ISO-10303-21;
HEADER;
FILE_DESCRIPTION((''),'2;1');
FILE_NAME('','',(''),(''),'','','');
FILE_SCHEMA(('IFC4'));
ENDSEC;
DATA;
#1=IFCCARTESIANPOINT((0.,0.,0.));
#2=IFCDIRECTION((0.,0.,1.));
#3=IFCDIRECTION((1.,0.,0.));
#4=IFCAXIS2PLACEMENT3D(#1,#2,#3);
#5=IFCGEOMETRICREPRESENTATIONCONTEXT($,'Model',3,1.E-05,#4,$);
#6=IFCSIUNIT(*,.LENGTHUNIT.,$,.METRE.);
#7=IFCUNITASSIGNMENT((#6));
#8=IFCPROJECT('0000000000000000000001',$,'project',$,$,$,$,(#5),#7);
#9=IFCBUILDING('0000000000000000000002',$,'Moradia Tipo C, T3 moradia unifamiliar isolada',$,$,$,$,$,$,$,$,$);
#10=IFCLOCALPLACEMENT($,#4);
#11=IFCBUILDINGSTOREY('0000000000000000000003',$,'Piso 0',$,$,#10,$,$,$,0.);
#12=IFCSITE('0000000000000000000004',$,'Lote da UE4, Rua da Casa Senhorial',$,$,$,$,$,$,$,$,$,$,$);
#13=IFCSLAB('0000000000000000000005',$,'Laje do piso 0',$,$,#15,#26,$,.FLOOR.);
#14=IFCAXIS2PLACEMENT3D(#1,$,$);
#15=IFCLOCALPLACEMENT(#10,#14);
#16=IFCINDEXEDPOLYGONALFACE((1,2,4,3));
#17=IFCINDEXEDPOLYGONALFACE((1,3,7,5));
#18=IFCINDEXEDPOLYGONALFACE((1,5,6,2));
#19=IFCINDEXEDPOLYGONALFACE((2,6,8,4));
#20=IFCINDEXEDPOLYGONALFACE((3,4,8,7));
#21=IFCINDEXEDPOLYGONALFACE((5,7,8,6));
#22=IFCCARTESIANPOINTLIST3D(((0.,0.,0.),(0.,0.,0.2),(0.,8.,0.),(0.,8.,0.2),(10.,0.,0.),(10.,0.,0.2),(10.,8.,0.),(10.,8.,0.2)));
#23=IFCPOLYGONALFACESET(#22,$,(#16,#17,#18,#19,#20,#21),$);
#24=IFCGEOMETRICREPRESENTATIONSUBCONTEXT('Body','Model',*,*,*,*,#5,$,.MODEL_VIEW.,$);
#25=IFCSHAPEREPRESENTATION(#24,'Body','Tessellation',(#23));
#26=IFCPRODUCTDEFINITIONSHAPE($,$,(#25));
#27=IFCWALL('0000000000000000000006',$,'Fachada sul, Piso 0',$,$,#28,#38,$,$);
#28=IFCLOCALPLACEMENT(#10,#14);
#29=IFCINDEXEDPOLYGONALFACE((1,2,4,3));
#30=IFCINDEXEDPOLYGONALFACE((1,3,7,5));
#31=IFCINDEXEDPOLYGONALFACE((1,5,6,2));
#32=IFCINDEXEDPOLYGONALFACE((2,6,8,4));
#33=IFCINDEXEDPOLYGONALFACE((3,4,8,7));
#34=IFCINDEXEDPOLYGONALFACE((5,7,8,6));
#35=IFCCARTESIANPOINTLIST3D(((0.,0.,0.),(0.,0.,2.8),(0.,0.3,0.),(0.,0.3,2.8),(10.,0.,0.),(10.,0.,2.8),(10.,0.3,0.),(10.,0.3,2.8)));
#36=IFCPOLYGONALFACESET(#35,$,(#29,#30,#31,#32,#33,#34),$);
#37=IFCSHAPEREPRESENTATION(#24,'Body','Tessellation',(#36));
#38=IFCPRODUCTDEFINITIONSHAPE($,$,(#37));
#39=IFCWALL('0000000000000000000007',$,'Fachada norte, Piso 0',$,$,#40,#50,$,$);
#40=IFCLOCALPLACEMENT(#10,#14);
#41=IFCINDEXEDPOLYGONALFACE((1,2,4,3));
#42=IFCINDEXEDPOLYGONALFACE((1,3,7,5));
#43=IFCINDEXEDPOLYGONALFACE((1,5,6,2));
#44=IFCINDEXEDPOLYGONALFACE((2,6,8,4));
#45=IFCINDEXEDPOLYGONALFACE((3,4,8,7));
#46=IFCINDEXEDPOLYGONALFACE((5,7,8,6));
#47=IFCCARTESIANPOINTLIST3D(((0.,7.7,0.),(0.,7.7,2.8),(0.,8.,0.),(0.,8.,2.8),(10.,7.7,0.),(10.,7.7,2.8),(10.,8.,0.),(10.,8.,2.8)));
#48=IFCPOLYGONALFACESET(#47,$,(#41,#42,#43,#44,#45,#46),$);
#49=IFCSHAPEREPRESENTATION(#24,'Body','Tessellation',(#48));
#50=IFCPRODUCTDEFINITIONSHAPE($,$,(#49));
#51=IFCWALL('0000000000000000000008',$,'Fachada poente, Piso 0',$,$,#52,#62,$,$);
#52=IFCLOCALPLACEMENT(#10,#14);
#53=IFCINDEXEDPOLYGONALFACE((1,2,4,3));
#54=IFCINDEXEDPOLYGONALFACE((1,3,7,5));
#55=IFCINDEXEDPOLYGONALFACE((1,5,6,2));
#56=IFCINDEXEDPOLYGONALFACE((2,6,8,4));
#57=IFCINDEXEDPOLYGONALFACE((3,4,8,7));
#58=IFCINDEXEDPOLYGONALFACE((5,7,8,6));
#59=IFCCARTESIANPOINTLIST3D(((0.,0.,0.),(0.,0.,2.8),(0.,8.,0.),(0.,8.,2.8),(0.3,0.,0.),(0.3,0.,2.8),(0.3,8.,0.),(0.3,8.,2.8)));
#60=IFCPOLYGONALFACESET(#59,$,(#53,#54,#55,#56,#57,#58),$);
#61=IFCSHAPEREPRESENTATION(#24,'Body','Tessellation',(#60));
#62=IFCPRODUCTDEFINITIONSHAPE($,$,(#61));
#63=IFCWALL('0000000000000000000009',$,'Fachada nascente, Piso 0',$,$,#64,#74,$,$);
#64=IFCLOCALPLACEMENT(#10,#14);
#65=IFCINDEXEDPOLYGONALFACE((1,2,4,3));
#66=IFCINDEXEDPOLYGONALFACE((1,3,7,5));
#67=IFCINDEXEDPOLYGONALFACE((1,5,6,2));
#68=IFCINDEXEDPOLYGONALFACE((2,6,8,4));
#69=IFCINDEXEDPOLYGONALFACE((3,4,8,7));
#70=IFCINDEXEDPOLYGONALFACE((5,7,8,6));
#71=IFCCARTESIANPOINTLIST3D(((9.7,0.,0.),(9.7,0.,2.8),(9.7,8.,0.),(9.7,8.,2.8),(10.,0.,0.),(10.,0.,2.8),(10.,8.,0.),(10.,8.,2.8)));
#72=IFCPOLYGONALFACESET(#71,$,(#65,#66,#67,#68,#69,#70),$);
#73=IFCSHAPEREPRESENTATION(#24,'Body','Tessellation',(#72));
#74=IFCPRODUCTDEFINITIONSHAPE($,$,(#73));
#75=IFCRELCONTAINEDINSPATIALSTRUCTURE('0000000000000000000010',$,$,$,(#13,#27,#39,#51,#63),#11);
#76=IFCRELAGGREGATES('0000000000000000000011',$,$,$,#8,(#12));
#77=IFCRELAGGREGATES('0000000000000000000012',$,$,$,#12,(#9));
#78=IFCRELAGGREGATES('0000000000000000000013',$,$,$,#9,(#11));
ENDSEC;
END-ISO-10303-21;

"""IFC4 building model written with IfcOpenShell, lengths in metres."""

from ifc_helpers import new_model, si_unit, frame, origin_with_axes, place, context, subcontext, project, spatial, indexed_curve, outline, extrude, element, save


model = new_model("IFC4")

# Units and contexts
model_context = context("Model", 3, precision=1e-05, world=origin_with_axes())
body_context = subcontext(model_context, "Body", "Model", "MODEL_VIEW")
ifc_project = project(units=[si_unit("LENGTHUNIT", "METRE")], contexts=[model_context])

# Site, building, storey
site = spatial("IfcSite", under=ifc_project, Name="Lote da UE4, Rua da Casa Senhorial")
building = spatial("IfcBuilding", under=site, Name="Moradia Tipo C, T3 moradia unifamiliar isolada")
storey_placement = place(None, origin_with_axes())
storey = spatial("IfcBuildingStorey", under=building, at=storey_placement, Name="Piso 0", Elevation=0.0)

# Slab
slab_placement = place(storey_placement, origin_with_axes())
element("IfcSlab", 1, at=slab_placement, inside=storey, Name="Laje do piso 0", PredefinedType="FLOOR", context=body_context, shape_type="SweptSolid", body=[
    extrude(outline(indexed_curve([(0.0, 0.0), (10.0, 0.0), (10.0, 8.0), (0.0, 8.0), (0.0, 0.0)])), None, (0.0, 0.0, 1.0), 0.2),
])

# Walls
for number, where, z_axis, x_axis, name in (
    (2, (0.0, 0.0, 0.0), (0.0, 0.0, 1.0), (1.0, 0.0, 0.0), "Fachada sul, Piso 0"),
    (3, (0.0, 7.7, 0.0), (0.0, 0.0, 1.0), (1.0, 0.0, 0.0), "Fachada norte, Piso 0"),
):
    element("IfcWall", number, at=place(storey_placement, frame(where, z_axis=z_axis, x_axis=x_axis)), inside=storey, Name=name, context=body_context, shape_type="SweptSolid", body=[
        extrude(outline(indexed_curve([(0.0, 0.0), (0.0, 0.3), (10.0, 0.3), (10.0, 0.0), (0.0, 0.0)], self_intersect=False)), origin_with_axes(), (0.0, 0.0, 1.0), 2.8),
    ])
for number, where, z_axis, x_axis, name in (
    (4, (0.3, 0.0, 0.0), (0.0, 0.0, 1.0), (0.0, 1.0, 0.0), "Fachada poente, Piso 0"),
    (5, (10.0, 0.0, 0.0), (0.0, 0.0, 1.0), (0.0, 1.0, 0.0), "Fachada nascente, Piso 0"),
):
    element("IfcWall", number, at=place(storey_placement, frame(where, z_axis=z_axis, x_axis=x_axis)), inside=storey, Name=name, context=body_context, shape_type="SweptSolid", body=[
        extrude(outline(indexed_curve([(0.0, 0.0), (0.0, 0.3), (8.0, 0.3), (8.0, 0.0), (0.0, 0.0)], self_intersect=False)), origin_with_axes(), (0.0, 0.0, 1.0), 2.8),
    ])

save(model, "model.ifc")
